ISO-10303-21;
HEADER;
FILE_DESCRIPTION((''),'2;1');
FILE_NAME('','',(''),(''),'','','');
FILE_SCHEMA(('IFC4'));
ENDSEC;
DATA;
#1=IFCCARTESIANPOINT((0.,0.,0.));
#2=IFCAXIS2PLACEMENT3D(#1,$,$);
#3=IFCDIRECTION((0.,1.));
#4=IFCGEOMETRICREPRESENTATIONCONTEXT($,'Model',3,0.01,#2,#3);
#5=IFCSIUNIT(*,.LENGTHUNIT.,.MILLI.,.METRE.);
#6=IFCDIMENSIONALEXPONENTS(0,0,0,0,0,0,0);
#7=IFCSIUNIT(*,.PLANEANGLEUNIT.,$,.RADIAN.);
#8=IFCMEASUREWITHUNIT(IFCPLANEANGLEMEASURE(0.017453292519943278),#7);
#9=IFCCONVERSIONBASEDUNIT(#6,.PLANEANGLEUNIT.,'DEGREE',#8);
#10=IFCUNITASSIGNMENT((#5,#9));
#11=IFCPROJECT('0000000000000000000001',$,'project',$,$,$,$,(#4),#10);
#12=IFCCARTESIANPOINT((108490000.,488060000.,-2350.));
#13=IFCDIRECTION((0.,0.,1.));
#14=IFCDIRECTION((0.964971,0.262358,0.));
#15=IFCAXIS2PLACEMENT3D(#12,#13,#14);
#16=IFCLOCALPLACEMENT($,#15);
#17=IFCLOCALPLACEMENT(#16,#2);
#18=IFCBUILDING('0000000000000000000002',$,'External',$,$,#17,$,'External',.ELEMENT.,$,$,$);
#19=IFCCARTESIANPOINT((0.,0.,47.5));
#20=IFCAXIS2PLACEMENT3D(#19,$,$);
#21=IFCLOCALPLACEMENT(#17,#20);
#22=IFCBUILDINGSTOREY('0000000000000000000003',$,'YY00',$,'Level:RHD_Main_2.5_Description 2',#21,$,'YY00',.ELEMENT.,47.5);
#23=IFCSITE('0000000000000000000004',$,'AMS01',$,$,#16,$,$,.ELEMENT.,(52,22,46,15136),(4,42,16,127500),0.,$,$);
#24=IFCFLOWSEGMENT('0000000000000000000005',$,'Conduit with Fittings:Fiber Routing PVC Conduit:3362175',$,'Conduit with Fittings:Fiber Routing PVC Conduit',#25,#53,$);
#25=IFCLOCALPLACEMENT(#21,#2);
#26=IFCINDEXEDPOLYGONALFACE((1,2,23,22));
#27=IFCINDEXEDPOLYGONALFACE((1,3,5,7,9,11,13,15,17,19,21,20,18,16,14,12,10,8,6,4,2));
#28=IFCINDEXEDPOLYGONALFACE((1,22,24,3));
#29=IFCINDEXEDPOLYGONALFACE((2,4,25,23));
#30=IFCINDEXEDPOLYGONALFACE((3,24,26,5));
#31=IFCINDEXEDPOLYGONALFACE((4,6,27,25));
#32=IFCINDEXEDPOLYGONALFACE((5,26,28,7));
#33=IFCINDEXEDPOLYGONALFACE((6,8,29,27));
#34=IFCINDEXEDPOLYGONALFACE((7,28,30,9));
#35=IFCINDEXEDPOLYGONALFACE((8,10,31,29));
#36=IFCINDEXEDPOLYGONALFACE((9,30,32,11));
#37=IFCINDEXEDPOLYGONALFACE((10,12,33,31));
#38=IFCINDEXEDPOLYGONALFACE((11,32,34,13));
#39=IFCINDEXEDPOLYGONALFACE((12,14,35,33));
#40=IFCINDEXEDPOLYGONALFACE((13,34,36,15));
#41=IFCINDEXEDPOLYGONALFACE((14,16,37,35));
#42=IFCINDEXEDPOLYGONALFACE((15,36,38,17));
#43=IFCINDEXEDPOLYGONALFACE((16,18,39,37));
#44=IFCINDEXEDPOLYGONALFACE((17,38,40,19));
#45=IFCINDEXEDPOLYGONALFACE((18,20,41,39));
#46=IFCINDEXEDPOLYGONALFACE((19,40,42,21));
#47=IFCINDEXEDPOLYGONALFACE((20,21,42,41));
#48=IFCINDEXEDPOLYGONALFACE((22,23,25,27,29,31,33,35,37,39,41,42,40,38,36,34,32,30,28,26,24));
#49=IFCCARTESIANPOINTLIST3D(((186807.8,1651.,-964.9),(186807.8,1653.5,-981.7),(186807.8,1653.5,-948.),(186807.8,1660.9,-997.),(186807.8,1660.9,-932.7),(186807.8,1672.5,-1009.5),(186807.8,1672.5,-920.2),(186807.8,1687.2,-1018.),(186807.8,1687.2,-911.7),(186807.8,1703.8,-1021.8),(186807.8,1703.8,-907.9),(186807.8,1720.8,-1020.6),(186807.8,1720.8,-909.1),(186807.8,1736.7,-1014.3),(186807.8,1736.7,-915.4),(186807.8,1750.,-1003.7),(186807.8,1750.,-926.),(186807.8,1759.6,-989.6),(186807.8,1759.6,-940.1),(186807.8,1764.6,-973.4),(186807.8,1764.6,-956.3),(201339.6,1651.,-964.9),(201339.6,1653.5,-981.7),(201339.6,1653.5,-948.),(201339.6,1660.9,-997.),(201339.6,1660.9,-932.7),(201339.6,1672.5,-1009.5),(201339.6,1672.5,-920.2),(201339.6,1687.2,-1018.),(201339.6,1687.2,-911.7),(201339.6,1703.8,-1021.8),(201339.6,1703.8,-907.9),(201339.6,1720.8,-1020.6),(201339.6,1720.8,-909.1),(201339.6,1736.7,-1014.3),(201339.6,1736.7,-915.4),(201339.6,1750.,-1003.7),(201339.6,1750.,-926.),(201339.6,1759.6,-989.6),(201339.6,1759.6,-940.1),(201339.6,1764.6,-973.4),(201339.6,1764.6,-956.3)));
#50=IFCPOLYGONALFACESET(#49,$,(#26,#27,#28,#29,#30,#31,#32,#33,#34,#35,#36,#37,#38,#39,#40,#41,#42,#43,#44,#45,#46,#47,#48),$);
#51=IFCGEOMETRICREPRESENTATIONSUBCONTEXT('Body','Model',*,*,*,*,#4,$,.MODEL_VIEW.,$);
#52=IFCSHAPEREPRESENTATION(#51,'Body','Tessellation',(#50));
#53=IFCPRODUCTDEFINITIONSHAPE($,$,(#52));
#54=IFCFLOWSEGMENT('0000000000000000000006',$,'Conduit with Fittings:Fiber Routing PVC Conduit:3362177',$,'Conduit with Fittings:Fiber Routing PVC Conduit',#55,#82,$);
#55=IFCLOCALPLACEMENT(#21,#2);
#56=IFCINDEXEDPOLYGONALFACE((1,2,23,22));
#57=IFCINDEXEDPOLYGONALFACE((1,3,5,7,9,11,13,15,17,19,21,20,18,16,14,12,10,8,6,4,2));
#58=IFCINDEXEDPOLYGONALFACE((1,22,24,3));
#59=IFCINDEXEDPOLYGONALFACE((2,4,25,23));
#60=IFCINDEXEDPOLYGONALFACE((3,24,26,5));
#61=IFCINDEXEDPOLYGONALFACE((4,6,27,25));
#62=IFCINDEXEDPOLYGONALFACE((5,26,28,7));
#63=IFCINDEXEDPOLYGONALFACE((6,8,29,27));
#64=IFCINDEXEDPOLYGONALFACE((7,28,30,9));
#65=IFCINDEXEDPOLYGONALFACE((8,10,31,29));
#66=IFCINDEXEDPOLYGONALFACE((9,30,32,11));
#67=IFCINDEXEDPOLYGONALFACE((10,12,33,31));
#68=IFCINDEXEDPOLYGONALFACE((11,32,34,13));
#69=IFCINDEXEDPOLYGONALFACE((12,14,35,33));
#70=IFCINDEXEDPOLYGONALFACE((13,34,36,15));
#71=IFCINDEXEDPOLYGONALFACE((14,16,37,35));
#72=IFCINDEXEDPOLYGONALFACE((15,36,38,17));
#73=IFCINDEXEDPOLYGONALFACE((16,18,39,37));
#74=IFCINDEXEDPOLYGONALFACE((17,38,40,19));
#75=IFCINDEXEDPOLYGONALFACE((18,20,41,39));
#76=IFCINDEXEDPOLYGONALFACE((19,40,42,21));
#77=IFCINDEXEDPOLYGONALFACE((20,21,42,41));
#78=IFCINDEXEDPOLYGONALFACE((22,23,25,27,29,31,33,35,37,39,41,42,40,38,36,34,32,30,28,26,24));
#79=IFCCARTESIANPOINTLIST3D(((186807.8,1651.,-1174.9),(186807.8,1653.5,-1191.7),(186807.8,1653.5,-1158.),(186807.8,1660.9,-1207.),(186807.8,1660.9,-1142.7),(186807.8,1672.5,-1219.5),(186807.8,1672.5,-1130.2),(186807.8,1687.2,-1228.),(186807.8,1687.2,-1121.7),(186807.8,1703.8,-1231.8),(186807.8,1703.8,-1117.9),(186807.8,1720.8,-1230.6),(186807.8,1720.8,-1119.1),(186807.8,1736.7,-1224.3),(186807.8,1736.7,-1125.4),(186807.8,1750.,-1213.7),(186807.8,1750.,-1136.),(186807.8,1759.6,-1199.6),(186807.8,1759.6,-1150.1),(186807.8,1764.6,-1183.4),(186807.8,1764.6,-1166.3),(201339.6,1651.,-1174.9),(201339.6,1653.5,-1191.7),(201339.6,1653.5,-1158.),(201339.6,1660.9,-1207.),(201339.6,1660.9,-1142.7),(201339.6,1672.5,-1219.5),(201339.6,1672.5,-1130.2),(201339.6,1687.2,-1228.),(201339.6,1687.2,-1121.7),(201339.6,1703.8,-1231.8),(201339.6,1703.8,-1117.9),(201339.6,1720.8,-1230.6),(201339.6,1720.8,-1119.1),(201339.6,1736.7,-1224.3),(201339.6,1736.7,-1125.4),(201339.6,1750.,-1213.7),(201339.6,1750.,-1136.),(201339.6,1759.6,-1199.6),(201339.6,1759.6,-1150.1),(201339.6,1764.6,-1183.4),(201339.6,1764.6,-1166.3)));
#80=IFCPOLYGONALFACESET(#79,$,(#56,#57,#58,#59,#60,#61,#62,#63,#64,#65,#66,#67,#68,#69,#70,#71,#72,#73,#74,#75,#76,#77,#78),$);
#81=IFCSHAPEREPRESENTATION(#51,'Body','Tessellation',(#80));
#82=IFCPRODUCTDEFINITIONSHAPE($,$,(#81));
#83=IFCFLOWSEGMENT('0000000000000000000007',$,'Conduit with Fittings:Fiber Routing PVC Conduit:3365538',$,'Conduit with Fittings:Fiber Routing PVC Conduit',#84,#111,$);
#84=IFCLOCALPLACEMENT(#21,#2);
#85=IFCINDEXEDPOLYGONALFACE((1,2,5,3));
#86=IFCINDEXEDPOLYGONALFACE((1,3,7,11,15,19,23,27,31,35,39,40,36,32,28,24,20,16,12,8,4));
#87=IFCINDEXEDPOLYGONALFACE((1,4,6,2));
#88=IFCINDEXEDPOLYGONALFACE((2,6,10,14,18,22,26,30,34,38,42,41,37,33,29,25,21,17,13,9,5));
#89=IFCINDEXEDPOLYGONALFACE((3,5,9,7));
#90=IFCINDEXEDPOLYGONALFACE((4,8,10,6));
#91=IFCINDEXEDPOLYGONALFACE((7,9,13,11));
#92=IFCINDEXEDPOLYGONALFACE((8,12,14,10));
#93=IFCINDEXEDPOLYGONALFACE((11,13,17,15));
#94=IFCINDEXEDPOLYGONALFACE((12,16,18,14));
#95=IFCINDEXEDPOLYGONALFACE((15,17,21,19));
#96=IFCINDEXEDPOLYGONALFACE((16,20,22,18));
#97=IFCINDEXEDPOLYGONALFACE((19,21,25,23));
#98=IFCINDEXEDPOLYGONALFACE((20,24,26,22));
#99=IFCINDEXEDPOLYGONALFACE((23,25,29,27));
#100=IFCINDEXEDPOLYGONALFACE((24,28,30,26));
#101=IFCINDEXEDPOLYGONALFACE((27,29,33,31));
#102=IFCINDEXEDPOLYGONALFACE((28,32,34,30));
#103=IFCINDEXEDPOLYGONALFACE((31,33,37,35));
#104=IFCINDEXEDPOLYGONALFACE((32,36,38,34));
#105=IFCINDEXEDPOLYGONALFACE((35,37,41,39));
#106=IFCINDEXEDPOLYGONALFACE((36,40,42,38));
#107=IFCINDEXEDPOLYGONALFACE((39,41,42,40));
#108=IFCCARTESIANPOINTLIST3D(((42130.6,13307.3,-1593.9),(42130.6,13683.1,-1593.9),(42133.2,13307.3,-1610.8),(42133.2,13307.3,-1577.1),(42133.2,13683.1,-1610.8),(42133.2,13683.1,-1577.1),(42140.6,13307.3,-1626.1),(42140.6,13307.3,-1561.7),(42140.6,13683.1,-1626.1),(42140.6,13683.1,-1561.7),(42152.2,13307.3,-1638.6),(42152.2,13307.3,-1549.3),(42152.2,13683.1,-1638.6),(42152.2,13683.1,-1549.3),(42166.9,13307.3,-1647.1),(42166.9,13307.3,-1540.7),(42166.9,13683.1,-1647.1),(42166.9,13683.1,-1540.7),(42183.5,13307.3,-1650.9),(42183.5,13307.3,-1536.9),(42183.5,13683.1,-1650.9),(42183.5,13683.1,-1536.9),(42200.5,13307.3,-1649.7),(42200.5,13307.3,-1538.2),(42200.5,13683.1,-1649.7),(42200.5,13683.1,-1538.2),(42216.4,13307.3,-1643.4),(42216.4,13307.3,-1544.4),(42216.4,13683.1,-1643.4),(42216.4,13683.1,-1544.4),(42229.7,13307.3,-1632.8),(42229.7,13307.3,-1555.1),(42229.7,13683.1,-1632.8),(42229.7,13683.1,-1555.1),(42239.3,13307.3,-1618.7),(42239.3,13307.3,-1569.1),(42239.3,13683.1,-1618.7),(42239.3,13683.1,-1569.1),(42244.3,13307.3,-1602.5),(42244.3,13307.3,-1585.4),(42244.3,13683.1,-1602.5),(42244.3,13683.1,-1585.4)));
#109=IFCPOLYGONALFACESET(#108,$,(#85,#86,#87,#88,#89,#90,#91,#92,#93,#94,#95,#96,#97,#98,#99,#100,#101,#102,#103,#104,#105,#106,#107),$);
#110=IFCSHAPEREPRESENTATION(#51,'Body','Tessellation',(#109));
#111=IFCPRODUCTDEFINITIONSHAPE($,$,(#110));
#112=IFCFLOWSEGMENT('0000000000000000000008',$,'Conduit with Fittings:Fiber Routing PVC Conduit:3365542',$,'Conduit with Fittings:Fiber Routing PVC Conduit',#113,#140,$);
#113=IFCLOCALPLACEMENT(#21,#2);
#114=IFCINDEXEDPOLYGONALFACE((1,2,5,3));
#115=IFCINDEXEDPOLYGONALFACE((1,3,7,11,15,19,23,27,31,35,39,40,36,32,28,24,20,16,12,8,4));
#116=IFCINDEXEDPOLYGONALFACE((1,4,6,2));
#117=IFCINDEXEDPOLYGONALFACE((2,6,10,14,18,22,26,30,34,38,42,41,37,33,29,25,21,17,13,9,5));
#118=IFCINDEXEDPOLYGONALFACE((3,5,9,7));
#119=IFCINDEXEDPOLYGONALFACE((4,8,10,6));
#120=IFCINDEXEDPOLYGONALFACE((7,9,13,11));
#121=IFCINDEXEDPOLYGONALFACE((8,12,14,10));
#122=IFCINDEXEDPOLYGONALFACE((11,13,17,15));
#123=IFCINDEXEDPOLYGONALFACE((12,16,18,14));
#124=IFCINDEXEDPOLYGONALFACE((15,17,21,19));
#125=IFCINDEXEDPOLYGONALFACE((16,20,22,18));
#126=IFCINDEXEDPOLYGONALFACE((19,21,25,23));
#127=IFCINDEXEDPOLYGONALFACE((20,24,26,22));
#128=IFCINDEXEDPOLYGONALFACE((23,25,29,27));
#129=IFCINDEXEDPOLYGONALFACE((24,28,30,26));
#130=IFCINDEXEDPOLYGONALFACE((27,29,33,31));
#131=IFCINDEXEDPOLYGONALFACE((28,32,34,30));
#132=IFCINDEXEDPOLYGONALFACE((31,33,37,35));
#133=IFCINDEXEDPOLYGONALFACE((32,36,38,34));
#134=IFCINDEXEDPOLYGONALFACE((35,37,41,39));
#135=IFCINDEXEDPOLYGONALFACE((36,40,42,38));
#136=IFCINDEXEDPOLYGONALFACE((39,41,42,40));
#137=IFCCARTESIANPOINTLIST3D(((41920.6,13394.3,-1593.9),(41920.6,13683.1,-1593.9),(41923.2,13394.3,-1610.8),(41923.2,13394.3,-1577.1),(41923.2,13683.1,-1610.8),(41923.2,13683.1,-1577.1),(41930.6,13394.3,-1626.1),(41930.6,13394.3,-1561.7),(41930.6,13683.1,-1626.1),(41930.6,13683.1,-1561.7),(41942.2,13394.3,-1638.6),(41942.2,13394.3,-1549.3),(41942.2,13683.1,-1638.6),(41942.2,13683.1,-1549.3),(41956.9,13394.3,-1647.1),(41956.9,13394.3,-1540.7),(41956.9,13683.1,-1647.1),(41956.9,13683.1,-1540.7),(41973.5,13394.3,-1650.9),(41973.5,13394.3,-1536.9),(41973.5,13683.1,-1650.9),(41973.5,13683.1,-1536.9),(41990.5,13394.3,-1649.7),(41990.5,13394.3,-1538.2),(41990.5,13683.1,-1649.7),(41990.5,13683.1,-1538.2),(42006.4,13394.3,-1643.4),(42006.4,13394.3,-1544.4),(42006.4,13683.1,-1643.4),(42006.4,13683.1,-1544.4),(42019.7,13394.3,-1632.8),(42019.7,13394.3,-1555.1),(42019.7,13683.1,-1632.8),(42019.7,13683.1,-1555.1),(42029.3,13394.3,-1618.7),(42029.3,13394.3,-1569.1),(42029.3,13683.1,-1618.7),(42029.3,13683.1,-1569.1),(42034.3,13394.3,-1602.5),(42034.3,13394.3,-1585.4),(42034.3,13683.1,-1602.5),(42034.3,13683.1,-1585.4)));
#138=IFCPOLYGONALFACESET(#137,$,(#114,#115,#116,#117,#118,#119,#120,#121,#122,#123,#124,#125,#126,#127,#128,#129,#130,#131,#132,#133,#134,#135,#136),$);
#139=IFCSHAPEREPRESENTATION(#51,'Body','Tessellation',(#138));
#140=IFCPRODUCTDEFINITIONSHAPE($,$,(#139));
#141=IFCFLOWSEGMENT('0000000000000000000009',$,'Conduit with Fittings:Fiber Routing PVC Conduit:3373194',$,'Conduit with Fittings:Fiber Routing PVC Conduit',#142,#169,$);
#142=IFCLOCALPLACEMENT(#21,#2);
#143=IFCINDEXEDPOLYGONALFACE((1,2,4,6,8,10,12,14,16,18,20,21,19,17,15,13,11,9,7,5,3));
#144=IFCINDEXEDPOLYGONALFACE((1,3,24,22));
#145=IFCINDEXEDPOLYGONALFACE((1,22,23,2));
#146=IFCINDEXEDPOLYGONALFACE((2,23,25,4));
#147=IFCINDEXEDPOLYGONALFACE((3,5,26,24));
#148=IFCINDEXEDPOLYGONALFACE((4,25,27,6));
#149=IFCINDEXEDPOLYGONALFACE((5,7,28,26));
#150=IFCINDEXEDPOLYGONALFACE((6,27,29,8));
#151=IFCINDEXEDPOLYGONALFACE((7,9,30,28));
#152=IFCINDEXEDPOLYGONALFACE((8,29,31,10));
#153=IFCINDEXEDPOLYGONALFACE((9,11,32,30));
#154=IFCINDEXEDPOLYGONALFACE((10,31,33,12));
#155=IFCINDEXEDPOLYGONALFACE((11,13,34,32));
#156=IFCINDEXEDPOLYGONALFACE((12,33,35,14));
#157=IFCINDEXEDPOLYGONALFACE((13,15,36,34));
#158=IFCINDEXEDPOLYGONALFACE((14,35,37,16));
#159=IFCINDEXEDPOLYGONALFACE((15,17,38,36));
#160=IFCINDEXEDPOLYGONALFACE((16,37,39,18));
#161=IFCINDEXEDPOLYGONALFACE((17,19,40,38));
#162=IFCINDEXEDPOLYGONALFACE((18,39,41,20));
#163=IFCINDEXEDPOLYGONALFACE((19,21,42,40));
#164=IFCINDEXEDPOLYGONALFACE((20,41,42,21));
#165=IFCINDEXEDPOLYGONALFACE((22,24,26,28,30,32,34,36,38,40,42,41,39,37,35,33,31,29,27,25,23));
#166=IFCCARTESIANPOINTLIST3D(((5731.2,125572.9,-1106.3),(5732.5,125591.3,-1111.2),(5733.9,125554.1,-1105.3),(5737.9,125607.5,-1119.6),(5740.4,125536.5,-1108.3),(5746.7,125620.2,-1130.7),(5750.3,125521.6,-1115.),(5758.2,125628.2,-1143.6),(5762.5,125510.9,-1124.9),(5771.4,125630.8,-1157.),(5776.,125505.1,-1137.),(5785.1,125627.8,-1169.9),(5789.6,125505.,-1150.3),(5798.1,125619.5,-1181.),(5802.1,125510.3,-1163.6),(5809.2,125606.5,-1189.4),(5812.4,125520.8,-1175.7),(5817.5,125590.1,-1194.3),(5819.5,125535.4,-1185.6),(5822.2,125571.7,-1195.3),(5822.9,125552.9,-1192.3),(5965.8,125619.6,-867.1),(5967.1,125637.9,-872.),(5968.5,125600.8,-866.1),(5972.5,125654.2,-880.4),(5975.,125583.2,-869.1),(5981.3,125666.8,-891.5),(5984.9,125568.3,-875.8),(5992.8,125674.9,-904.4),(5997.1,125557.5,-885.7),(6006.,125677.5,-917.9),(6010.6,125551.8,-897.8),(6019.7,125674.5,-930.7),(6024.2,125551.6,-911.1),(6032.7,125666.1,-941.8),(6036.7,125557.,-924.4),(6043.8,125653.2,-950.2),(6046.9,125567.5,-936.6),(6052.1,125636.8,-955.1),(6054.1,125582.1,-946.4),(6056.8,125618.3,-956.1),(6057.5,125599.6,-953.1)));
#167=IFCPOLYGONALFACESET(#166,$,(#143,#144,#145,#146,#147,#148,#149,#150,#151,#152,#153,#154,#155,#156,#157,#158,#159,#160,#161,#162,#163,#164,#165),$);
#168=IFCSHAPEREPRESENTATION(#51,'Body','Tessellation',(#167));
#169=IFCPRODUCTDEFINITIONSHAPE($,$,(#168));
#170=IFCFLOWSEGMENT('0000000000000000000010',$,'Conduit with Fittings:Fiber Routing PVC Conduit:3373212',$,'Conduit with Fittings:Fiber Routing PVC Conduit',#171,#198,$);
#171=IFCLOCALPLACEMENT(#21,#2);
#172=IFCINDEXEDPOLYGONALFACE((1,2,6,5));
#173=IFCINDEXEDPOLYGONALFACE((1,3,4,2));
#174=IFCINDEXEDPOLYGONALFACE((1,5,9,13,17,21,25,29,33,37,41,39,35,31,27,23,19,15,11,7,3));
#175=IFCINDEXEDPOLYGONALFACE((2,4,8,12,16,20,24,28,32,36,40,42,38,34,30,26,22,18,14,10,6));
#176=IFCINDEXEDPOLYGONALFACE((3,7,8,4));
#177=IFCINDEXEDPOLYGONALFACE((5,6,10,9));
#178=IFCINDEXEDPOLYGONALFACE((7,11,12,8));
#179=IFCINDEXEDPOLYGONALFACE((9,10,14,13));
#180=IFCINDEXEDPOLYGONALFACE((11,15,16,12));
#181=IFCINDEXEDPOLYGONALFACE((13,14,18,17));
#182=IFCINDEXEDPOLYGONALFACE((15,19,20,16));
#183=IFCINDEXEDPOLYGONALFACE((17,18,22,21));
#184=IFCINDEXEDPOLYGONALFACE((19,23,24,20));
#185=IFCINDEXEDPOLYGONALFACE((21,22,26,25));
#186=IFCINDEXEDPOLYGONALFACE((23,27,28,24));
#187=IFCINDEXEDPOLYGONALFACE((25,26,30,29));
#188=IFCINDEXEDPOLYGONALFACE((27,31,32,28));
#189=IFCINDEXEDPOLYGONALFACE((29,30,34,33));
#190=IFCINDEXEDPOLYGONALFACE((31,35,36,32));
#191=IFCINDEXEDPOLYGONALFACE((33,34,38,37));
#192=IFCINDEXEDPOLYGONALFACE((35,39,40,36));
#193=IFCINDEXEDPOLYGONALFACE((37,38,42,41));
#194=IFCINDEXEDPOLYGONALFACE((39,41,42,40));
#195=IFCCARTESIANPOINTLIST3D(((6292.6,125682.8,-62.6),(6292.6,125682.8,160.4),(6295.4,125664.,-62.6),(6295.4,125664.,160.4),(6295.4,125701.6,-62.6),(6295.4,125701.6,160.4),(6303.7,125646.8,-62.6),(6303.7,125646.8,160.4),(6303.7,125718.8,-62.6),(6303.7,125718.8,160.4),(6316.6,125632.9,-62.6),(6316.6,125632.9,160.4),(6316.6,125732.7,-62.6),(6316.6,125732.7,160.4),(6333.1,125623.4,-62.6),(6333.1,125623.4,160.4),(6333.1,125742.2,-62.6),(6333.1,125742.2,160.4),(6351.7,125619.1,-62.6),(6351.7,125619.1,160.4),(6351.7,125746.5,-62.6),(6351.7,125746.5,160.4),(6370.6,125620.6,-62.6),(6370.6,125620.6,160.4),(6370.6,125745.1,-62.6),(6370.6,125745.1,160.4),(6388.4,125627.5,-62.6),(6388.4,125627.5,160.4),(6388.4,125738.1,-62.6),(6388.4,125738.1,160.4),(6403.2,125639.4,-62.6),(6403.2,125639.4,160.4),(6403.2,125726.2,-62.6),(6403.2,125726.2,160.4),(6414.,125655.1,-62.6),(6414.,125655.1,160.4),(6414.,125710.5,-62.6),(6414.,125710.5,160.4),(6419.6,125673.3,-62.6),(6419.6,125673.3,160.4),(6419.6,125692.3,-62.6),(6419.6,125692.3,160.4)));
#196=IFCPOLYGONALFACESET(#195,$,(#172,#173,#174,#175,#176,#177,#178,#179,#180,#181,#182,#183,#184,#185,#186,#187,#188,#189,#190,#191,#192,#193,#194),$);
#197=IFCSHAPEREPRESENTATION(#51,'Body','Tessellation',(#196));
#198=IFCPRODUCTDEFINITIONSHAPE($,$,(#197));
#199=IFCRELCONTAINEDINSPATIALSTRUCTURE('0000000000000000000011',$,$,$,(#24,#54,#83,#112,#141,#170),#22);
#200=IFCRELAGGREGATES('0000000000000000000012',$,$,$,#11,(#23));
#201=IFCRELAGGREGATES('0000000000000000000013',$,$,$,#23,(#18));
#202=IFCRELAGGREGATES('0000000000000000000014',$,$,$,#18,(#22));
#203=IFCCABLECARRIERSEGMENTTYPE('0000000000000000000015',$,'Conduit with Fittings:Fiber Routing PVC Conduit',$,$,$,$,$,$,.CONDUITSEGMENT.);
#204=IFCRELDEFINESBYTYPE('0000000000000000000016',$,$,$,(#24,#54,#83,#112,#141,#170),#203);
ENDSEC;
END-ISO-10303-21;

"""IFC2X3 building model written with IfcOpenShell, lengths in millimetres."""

from ifc_helpers import new_model, entity, si_unit, converted_unit, direction, frame, frame_2d, origin, origin_2d_with_axis, place, context, subcontext, project, spatial, circle, extrude, type_object, element, save


model = new_model("IFC2X3")

# Units and contexts
model_context = context("Model", 3, precision=0.01, world=origin(), true_north=direction((0.0, 1.0)))
body_context = subcontext(model_context, "Body", "Model", "MODEL_VIEW")
ifc_project = project(units=[si_unit("LENGTHUNIT", "METRE", prefix="MILLI"), converted_unit("PLANEANGLEUNIT", "DEGREE", entity("IfcPlaneAngleMeasure", 0.017453292519943278), si_unit("PLANEANGLEUNIT", "RADIAN"), dimensions=[0, 0, 0, 0, 0, 0, 0])], contexts=[model_context])

# Site, building, storey
site_placement = place(None, frame((108490000.0, 488060000.0, -2350.0), z_axis=(0.0, 0.0, 1.0), x_axis=(0.964971, 0.262358, 0.0)))
site = spatial("IfcSite", under=ifc_project, at=site_placement, Name="AMS01", CompositionType="ELEMENT", RefLatitude=(52, 22, 46, 15136), RefLongitude=(4, 42, 16, 127500), RefElevation=0.0)
building_placement = place(site_placement, origin())
building = spatial("IfcBuilding", under=site, at=building_placement, Name="External", LongName="External", CompositionType="ELEMENT")
storey_placement = place(building_placement, frame((0.0, 0.0, 47.5)))
storey = spatial("IfcBuildingStorey", under=building, at=storey_placement, Name="YY00", ObjectType="Level:RHD_Main_2.5_Description 2", LongName="YY00", CompositionType="ELEMENT", Elevation=47.5)

# Flow segments
cable_carrier_segment_type = type_object("IfcCableCarrierSegmentType", Name="Conduit with Fittings:Fiber Routing PVC Conduit", PredefinedType="CONDUITSEGMENT")
flow_segment_1_placement = place(storey_placement, origin())
element("IfcFlowSegment", 1, at=flow_segment_1_placement, inside=storey, type_object=cable_carrier_segment_type, Name="Conduit with Fittings:Fiber Routing PVC Conduit:3362175", ObjectType="Conduit with Fittings:Fiber Routing PVC Conduit", context=body_context, shape_type="SweptSolid", body=[
    extrude(circle(Radius=57.2, at=frame_2d((0.0, 0.0), x_axis=(1.0, 0.0))), frame((186807.8, 1708.1, -964.9), z_axis=(1.0, 0.0, 0.0), x_axis=(0.0, -1.0, 0.0)), (0.0, 0.0, 1.0), 14531.7),
])
flow_segment_2_placement = place(storey_placement, origin())
element("IfcFlowSegment", 2, at=flow_segment_2_placement, inside=storey, type_object=cable_carrier_segment_type, Name="Conduit with Fittings:Fiber Routing PVC Conduit:3362177", ObjectType="Conduit with Fittings:Fiber Routing PVC Conduit", context=body_context, shape_type="SweptSolid", body=[
    extrude(circle(Radius=57.2, at=origin_2d_with_axis()), frame((186807.8, 1708.1, -1174.9), z_axis=(1.0, 0.0, 0.0), x_axis=(0.0, -1.0, 0.0)), (0.0, 0.0, 1.0), 14531.7),
])
flow_segment_3_placement = place(storey_placement, origin())
element("IfcFlowSegment", 3, at=flow_segment_3_placement, inside=storey, type_object=cable_carrier_segment_type, Name="Conduit with Fittings:Fiber Routing PVC Conduit:3365538", ObjectType="Conduit with Fittings:Fiber Routing PVC Conduit", context=body_context, shape_type="SweptSolid", body=[
    extrude(circle(Radius=57.2, at=frame_2d((0.0, 0.0), x_axis=(1.0, 0.0))), frame((42187.8, 13307.3, -1593.9), z_axis=(0.0, 1.0, 0.0), x_axis=(-1.0, 0.0, 0.0)), (0.0, 0.0, 1.0), 375.8),
])
flow_segment_4_placement = place(storey_placement, origin())
element("IfcFlowSegment", 4, at=flow_segment_4_placement, inside=storey, type_object=cable_carrier_segment_type, Name="Conduit with Fittings:Fiber Routing PVC Conduit:3365542", ObjectType="Conduit with Fittings:Fiber Routing PVC Conduit", context=body_context, shape_type="SweptSolid", body=[
    extrude(circle(Radius=57.2, at=frame_2d((0.0, 0.0), x_axis=(1.0, 0.0))), frame((41977.8, 13394.3, -1593.9), z_axis=(0.0, 1.0, 0.0), x_axis=(-1.0, 0.0, 0.0)), (0.0, 0.0, 1.0), 288.8),
])
flow_segment_5_placement = place(storey_placement, origin())
element("IfcFlowSegment", 5, at=flow_segment_5_placement, inside=storey, type_object=cable_carrier_segment_type, Name="Conduit with Fittings:Fiber Routing PVC Conduit:3373194", ObjectType="Conduit with Fittings:Fiber Routing PVC Conduit", context=body_context, shape_type="SweptSolid", body=[
    extrude(circle(Radius=63.9, at=origin_2d_with_axis()), frame((5777.1, 125567.6, -1150.3), z_axis=(0.69352, 0.13795, 0.707107), x_axis=(0.19509, -0.980785, 0.0)), (0.0, 0.0, 1.0), 338.3),
])
flow_segment_6_placement = place(storey_placement, origin())
element("IfcFlowSegment", 6, at=flow_segment_6_placement, inside=storey, type_object=cable_carrier_segment_type, Name="Conduit with Fittings:Fiber Routing PVC Conduit:3373212", ObjectType="Conduit with Fittings:Fiber Routing PVC Conduit", context=body_context, shape_type="SweptSolid", body=[
    extrude(circle(Radius=63.9, at=origin_2d_with_axis()), frame((6356.4, 125682.8, -62.6), z_axis=(0.0, 0.0, 1.0), x_axis=(-1.0, 0.0, 0.0)), (0.0, 0.0, 1.0), 222.9),
])

save(model, "model.ifc")
